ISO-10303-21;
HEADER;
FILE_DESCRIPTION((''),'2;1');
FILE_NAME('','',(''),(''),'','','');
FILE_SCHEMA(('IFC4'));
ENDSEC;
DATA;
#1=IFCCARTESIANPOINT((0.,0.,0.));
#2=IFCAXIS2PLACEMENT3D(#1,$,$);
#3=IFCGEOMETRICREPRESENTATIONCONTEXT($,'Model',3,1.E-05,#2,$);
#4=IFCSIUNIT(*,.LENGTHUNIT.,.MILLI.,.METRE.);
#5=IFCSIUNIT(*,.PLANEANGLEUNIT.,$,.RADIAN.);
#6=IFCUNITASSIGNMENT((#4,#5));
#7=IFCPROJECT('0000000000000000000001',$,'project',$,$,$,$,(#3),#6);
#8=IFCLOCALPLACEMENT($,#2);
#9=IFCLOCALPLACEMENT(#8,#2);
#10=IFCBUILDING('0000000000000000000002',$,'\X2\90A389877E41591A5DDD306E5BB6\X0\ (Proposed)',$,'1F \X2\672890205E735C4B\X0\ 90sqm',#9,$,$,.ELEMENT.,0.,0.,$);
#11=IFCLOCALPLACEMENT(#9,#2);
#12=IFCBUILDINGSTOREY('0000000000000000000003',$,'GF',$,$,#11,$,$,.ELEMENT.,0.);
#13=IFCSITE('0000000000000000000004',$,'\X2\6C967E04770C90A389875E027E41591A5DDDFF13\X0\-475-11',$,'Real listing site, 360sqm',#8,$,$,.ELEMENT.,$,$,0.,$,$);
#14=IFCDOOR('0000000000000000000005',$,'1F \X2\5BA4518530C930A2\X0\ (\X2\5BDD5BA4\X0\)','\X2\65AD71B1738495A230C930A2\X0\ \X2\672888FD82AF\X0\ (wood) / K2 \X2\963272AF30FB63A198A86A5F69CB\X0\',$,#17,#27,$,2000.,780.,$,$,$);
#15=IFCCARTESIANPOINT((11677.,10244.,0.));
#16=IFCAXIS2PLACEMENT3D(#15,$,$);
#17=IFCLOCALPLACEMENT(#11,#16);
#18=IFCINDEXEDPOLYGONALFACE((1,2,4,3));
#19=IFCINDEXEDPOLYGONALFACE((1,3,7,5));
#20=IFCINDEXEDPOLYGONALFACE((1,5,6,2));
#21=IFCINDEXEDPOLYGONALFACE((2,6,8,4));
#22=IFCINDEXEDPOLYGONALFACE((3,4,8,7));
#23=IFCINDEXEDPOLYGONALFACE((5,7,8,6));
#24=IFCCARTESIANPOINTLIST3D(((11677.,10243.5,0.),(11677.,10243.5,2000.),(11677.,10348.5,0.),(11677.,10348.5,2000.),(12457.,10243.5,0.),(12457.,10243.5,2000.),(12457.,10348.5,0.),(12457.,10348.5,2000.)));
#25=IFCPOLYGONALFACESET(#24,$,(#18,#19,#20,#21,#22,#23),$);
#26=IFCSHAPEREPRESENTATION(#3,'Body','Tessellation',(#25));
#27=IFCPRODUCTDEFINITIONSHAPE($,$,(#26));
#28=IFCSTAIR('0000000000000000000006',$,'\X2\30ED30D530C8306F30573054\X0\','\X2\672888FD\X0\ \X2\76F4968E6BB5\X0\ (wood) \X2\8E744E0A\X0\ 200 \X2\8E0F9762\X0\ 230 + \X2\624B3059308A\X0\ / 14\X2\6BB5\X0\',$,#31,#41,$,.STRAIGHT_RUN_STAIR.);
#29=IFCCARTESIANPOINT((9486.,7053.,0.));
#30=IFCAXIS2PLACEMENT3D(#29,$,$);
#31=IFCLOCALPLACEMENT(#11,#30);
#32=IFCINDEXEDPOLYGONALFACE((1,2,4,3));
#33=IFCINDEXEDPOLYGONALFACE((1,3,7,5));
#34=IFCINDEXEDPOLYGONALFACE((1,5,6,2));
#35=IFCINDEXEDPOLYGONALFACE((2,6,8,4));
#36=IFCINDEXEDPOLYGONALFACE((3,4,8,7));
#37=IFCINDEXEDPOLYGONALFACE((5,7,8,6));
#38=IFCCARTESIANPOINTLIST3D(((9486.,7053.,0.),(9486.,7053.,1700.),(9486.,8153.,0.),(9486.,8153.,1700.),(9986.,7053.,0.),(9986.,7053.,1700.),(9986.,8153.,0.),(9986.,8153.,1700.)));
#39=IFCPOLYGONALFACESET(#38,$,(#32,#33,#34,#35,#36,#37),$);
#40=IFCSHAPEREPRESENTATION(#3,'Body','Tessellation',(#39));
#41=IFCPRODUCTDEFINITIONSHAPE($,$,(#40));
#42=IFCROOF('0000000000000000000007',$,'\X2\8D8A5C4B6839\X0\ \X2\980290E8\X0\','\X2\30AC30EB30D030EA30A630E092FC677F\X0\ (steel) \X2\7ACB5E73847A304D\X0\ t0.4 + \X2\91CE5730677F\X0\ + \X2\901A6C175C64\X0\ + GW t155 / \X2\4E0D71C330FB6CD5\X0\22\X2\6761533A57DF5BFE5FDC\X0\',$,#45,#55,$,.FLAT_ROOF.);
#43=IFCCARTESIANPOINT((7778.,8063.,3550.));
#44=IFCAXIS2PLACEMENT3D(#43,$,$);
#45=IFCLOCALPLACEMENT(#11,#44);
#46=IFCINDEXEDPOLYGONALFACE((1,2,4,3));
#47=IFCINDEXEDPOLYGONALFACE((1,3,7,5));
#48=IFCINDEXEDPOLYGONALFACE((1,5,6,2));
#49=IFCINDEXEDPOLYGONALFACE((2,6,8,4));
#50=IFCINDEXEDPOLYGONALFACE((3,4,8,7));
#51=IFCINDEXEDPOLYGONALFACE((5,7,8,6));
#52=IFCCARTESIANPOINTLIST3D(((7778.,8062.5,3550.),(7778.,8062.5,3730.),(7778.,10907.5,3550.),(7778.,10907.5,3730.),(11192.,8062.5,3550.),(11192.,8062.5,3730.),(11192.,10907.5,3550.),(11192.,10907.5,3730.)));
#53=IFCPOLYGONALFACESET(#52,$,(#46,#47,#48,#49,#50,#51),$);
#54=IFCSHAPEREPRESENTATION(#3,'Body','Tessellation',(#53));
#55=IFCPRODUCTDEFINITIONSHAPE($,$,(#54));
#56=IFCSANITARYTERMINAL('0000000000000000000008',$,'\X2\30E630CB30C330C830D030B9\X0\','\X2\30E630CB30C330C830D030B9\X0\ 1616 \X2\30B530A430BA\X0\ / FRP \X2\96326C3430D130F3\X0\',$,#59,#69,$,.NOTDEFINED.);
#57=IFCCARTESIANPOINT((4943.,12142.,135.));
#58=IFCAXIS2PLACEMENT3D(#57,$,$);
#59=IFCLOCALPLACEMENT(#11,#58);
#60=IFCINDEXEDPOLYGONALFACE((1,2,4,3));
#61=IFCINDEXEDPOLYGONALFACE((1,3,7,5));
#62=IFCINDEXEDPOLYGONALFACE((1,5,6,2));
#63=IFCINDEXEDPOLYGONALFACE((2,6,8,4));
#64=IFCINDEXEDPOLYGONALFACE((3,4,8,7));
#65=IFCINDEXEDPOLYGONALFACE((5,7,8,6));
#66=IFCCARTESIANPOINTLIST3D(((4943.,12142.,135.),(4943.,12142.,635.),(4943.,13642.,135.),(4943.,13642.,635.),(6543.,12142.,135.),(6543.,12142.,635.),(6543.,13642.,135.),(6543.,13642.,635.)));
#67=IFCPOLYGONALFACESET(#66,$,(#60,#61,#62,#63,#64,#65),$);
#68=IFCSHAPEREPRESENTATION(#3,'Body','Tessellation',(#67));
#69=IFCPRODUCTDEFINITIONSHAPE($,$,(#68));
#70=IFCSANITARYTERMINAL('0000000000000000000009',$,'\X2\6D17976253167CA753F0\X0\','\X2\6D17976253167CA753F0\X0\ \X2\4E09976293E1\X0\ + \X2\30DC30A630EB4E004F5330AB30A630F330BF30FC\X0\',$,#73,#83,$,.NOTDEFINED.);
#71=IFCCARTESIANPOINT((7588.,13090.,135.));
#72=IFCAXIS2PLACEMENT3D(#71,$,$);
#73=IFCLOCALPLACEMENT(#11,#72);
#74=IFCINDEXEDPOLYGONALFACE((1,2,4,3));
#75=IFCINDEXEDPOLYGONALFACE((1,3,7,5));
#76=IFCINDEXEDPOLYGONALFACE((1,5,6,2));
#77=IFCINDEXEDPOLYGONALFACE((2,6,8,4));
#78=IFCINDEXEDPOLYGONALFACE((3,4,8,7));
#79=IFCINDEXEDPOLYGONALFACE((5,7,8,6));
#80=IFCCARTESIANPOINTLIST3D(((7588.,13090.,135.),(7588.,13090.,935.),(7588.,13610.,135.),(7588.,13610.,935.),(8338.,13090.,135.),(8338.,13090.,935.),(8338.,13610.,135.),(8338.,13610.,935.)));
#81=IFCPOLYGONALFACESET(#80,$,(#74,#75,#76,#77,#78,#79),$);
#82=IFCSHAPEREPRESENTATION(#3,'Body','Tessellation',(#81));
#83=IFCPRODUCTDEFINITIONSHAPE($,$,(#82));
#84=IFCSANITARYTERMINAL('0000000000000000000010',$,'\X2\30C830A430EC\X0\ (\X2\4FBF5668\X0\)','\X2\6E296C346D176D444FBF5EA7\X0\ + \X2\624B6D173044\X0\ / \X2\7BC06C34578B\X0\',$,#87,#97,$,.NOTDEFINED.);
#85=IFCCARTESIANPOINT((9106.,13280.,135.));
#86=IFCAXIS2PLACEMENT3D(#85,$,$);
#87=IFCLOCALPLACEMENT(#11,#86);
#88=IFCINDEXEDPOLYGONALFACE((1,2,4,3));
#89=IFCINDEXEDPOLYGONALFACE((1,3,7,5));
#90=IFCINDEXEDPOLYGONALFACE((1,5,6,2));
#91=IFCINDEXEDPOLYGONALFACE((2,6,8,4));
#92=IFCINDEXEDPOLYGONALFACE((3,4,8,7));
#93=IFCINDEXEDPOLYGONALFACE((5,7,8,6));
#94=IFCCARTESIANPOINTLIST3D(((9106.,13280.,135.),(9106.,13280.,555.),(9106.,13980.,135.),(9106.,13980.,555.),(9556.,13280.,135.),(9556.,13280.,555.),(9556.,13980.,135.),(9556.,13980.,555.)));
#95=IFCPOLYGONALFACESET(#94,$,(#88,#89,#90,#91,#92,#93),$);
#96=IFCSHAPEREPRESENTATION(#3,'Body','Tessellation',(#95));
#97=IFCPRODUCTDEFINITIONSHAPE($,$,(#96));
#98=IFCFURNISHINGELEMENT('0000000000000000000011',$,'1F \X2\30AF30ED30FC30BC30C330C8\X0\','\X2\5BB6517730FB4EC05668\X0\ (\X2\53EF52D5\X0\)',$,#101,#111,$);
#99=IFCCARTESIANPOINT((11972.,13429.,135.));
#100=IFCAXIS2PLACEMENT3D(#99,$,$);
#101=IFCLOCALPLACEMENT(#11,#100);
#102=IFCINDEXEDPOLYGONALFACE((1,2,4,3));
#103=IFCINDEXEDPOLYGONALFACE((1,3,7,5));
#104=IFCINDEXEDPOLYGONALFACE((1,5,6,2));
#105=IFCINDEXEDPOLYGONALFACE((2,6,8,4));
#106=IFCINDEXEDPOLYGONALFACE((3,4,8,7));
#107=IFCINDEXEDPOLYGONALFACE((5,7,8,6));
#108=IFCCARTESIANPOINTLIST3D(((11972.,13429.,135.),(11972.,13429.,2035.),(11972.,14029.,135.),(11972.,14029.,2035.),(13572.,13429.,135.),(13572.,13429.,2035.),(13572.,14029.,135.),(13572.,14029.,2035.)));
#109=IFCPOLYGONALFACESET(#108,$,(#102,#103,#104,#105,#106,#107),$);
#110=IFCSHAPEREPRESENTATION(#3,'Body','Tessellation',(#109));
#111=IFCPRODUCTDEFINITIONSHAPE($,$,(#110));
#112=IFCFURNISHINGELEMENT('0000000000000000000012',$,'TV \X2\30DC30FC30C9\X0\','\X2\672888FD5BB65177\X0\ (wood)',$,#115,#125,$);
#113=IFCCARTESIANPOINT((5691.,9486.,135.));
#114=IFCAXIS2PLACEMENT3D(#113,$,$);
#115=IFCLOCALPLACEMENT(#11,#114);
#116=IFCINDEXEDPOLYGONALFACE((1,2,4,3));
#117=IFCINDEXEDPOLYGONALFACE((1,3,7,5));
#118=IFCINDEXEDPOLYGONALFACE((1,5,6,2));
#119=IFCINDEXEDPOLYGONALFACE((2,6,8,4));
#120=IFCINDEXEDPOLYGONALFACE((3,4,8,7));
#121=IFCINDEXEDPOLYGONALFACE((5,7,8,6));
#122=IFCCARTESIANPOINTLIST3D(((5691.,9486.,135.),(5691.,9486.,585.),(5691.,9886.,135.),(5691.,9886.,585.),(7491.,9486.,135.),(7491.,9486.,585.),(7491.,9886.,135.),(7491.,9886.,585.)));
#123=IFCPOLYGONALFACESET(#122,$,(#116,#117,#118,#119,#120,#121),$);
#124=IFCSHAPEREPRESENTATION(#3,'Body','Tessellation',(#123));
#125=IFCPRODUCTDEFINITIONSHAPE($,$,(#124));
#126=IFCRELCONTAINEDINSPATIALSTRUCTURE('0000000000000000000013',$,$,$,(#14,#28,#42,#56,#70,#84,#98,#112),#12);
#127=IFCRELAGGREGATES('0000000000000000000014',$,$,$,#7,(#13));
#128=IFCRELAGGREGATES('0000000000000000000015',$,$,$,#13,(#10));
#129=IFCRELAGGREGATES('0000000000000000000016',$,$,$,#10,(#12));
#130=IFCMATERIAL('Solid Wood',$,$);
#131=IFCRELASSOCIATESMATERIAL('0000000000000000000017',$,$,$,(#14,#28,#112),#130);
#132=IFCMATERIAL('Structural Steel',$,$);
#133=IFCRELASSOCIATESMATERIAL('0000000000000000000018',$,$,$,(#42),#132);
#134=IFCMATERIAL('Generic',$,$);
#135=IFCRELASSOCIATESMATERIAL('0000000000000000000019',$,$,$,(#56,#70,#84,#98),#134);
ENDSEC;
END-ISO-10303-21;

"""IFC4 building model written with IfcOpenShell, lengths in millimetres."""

from ifc_helpers import new_model, si_unit, frame, frame_2d, origin, place, context, project, spatial, rectangle, extrude, material, element, save


model = new_model("IFC4")

# Units and contexts
model_context = context("Model", 3, precision=1e-05, world=origin())
ifc_project = project(units=[si_unit("LENGTHUNIT", "METRE", prefix="MILLI"), si_unit("PLANEANGLEUNIT", "RADIAN")], contexts=[model_context])

# Site, building, storey
site_placement = place(None, origin())
site = spatial("IfcSite", under=ifc_project, at=site_placement, Name="沖縄県那覇市繁多川３-475-11", ObjectType="Real listing site, 360sqm", CompositionType="ELEMENT", RefElevation=0.0)
building_placement = place(site_placement, origin())
building = spatial("IfcBuilding", under=site, at=building_placement, Name="那覇繁多川の家 (Proposed)", ObjectType="1F 木造平屋 90sqm", CompositionType="ELEMENT", ElevationOfRefHeight=0.0, ElevationOfTerrain=0.0)
storey_placement = place(building_placement, origin())
storey = spatial("IfcBuildingStorey", under=building, at=storey_placement, Name="GF", CompositionType="ELEMENT", Elevation=0.0)

# Shared definitions
ifc_material_1 = material(Name="Solid Wood")

# Door
door_1_placement = place(storey_placement, frame((11677.0, 10244.0, 0.0)))
element("IfcDoor", 1, at=door_1_placement, inside=storey, material=ifc_material_1, Name="1F 室内ドア (寝室)", Description="断熱玄関ドア 木製芯 (wood) / K2 防犯・採風機構", OverallHeight=2000.0, OverallWidth=780.0, context=model_context, shape_type="SweptSolid", body=[
    extrude(rectangle(XDim=780.0, YDim=105.0, at=frame_2d((390.0, 52.0))), frame((11677.0, 10244.0, 0.0)), (0.0, 0.0, 1.0), 2000.0),
])

# Stair
stair_placement = place(storey_placement, frame((9486.0, 7053.0, 0.0)))
element("IfcStair", 2, at=stair_placement, inside=storey, material=ifc_material_1, Name="ロフトはしご", Description="木製 直階段 (wood) 蹴上 200 踏面 230 + 手すり / 14段", PredefinedType="STRAIGHT_RUN_STAIR", context=model_context, shape_type="SweptSolid", body=[
    extrude(rectangle(XDim=500.0, YDim=1100.0, at=frame_2d((250.0, 550.0))), frame((9486.0, 7053.0, 0.0)), (0.0, 0.0, 1.0), 1700.0),
])

# Roof
ifc_material_2 = material(Name="Structural Steel")
roof_placement = place(storey_placement, frame((7778.0, 8063.0, 3550.0)))
element("IfcRoof", 3, at=roof_placement, inside=storey, material=ifc_material_2, Name="越屋根 頂部", Description="ガルバリウム鋼板 (steel) 立平葺き t0.4 + 野地板 + 通気層 + GW t155 / 不燃・法22条区域対応", PredefinedType="FLAT_ROOF", context=model_context, shape_type="SweptSolid", body=[
    extrude(rectangle(XDim=3414.0, YDim=2845.0, at=frame_2d((1707.0, 1422.0))), frame((7778.0, 8063.0, 3550.0)), (0.0, 0.0, 1.0), 180.0),
])

# Sanitary terminals
ifc_material_3 = material(Name="Generic")
sanitary_terminal_1_placement = place(storey_placement, frame((4943.0, 12142.0, 135.0)))
element("IfcSanitaryTerminal", 4, at=sanitary_terminal_1_placement, inside=storey, material=ifc_material_3, Name="ユニットバス", Description="ユニットバス 1616 サイズ / FRP 防水パン", PredefinedType="NOTDEFINED", context=model_context, shape_type="SweptSolid", body=[
    extrude(rectangle(XDim=1600.0, YDim=1500.0, at=frame_2d((800.0, 750.0))), frame((4943.0, 12142.0, 135.0)), (0.0, 0.0, 1.0), 500.0),
])
sanitary_terminal_2_placement = place(storey_placement, frame((7588.0, 13090.0, 135.0)))
element("IfcSanitaryTerminal", 5, at=sanitary_terminal_2_placement, inside=storey, material=ifc_material_3, Name="洗面化粧台", Description="洗面化粧台 三面鏡 + ボウル一体カウンター", PredefinedType="NOTDEFINED", context=model_context, shape_type="SweptSolid", body=[
    extrude(rectangle(XDim=750.0, YDim=520.0, at=frame_2d((375.0, 260.0))), frame((7588.0, 13090.0, 135.0)), (0.0, 0.0, 1.0), 800.0),
])
sanitary_terminal_3_placement = place(storey_placement, frame((9106.0, 13280.0, 135.0)))
element("IfcSanitaryTerminal", 6, at=sanitary_terminal_3_placement, inside=storey, material=ifc_material_3, Name="トイレ (便器)", Description="温水洗浄便座 + 手洗い / 節水型", PredefinedType="NOTDEFINED", context=model_context, shape_type="SweptSolid", body=[
    extrude(rectangle(XDim=450.0, YDim=700.0, at=frame_2d((225.0, 350.0))), frame((9106.0, 13280.0, 135.0)), (0.0, 0.0, 1.0), 420.0),
])

# Furnishing elements
furnishing_1_placement = place(storey_placement, frame((11972.0, 13429.0, 135.0)))
element("IfcFurnishingElement", 7, at=furnishing_1_placement, inside=storey, material=ifc_material_3, Name="1F クローゼット", Description="家具・什器 (可動)", context=model_context, shape_type="SweptSolid", body=[
    extrude(rectangle(XDim=1600.0, YDim=600.0, at=frame_2d((800.0, 300.0))), frame((11972.0, 13429.0, 135.0)), (0.0, 0.0, 1.0), 1900.0),
])
furnishing_2_placement = place(storey_placement, frame((5691.0, 9486.0, 135.0)))
element("IfcFurnishingElement", 8, at=furnishing_2_placement, inside=storey, material=ifc_material_1, Name="TV ボード", Description="木製家具 (wood)", context=model_context, shape_type="SweptSolid", body=[
    extrude(rectangle(XDim=1800.0, YDim=400.0, at=frame_2d((900.0, 200.0))), frame((5691.0, 9486.0, 135.0)), (0.0, 0.0, 1.0), 450.0),
])

save(model, "model.ifc")
